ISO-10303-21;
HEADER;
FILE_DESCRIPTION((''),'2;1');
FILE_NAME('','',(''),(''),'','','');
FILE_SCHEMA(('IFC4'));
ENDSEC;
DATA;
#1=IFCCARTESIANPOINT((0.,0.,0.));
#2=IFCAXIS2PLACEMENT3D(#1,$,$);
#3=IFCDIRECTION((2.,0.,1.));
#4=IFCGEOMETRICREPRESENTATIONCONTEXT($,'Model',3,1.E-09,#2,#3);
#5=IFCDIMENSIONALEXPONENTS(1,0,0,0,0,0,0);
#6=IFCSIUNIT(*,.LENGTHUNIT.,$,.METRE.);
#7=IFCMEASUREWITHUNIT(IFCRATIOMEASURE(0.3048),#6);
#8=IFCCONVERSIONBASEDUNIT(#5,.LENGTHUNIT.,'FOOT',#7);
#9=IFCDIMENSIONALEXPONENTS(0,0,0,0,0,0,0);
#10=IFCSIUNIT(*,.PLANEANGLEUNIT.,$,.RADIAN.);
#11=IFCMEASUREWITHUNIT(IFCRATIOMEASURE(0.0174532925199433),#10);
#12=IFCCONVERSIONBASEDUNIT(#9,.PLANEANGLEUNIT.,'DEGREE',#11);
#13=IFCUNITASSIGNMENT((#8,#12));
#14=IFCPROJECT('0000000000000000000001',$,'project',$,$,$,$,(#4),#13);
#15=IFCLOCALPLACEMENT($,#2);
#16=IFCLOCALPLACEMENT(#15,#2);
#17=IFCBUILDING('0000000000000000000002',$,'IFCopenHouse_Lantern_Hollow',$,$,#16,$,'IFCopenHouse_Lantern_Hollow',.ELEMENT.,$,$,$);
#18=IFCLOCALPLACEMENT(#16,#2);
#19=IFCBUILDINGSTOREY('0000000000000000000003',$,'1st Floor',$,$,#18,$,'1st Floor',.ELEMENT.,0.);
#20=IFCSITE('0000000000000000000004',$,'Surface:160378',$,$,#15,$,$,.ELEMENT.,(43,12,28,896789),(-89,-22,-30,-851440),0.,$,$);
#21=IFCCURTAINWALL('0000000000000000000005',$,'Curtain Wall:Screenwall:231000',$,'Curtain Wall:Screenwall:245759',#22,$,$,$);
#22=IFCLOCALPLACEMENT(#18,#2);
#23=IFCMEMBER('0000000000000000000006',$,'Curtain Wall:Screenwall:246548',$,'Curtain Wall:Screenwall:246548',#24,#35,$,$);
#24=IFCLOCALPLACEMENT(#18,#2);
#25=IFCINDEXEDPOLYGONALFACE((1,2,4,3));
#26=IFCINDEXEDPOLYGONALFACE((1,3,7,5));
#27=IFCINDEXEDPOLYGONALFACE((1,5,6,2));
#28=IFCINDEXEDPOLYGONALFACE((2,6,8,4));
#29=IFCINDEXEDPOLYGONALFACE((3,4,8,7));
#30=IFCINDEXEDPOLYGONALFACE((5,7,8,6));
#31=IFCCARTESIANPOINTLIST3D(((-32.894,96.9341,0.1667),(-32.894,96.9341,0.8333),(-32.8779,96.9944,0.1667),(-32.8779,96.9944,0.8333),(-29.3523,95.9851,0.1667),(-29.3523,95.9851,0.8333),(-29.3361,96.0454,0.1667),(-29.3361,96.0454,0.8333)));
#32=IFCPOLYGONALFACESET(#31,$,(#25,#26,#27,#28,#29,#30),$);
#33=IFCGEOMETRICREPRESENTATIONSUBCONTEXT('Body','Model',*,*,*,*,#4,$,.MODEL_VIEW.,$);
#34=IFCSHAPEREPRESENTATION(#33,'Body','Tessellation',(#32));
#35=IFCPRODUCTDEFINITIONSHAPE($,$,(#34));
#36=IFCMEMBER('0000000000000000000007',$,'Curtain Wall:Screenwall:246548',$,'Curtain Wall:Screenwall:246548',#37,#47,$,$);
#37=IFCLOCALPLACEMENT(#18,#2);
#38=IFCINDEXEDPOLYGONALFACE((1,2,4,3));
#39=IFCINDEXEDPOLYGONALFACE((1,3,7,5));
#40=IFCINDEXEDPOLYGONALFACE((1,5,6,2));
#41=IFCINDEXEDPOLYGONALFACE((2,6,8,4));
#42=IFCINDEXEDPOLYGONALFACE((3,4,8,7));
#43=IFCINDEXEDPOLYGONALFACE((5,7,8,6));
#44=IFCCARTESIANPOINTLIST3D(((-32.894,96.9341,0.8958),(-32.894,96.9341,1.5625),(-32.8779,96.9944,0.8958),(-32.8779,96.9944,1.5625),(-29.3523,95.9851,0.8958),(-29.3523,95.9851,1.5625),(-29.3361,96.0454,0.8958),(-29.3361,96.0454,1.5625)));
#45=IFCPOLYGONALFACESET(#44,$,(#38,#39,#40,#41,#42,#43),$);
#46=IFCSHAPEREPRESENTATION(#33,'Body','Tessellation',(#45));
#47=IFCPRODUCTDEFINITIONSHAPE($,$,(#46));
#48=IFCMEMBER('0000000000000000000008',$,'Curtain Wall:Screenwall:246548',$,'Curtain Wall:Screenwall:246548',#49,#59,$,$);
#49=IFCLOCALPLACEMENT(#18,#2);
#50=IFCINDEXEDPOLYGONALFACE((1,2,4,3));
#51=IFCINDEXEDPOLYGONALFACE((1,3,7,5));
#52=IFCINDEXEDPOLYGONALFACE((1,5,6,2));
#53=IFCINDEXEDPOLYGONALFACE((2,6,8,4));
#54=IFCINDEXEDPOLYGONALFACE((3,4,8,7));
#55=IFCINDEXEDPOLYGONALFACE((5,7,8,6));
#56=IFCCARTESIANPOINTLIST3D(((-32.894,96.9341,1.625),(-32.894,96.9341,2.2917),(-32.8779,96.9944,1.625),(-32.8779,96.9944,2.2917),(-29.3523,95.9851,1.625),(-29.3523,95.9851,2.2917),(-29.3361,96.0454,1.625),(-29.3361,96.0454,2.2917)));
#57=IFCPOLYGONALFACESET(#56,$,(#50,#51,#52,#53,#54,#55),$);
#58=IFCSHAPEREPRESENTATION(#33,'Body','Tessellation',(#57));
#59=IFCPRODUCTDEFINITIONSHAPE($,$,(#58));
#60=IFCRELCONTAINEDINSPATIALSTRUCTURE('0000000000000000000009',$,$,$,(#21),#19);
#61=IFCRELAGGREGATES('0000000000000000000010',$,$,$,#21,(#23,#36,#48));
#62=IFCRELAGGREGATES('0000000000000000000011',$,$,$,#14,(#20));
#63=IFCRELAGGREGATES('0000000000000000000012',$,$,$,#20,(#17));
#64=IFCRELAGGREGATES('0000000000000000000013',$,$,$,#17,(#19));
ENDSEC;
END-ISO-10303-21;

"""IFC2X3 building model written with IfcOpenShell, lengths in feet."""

from ifc_helpers import new_model, entity, si_unit, converted_unit, direction, frame, frame_2d, origin, place, context, subcontext, project, spatial, rectangle, extrude, element, aggregate, save


model = new_model("IFC2X3")

# Units and contexts
model_context = context("Model", 3, precision=1e-09, world=origin(), true_north=direction((2.0, 0.0, 1.0)))
body_context = subcontext(model_context, "Body", "Model", "MODEL_VIEW")
ifc_project = project(units=[converted_unit("LENGTHUNIT", "FOOT", entity("IfcRatioMeasure", 0.3048), si_unit("LENGTHUNIT", "METRE"), dimensions=[1, 0, 0, 0, 0, 0, 0]), converted_unit("PLANEANGLEUNIT", "DEGREE", entity("IfcRatioMeasure", 0.0174532925199433), si_unit("PLANEANGLEUNIT", "RADIAN"), dimensions=[0, 0, 0, 0, 0, 0, 0])], contexts=[model_context])

# Site, building, storey
site_placement = place(None, origin())
site = spatial("IfcSite", under=ifc_project, at=site_placement, Name="Surface:160378", CompositionType="ELEMENT", RefLatitude=(43, 12, 28, 896789), RefLongitude=(-89, -22, -30, -851440), RefElevation=0.0)
building_placement = place(site_placement, origin())
building = spatial("IfcBuilding", under=site, at=building_placement, Name="IFCopenHouse_Lantern_Hollow", LongName="IFCopenHouse_Lantern_Hollow", CompositionType="ELEMENT")
storey_placement = place(building_placement, origin())
storey = spatial("IfcBuildingStorey", under=building, at=storey_placement, Name="1st Floor", LongName="1st Floor", CompositionType="ELEMENT", Elevation=0.0)

# Curtain wall, members
curtain_wall_placement = place(storey_placement, origin())
curtain_wall = element("IfcCurtainWall", 1, at=curtain_wall_placement, inside=storey, Name="Curtain Wall:Screenwall:231000", ObjectType="Curtain Wall:Screenwall:245759")
member_1_placement = place(curtain_wall_placement, frame((-32.894, 95.9851, 0.1667)))
member_1 = element("IfcMember", 2, at=member_1_placement, Name="Curtain Wall:Screenwall:246548", ObjectType="Curtain Wall:Screenwall:246548", context=body_context, shape_type="SweptSolid", body=[
    extrude(rectangle(XDim=3.6667, YDim=0.0625, at=frame_2d((0.0, 0.0), x_axis=(1.0, 0.0))), frame((1.779, 0.5047, 0.0), z_axis=(0.0, 0.0, 1.0), x_axis=(-0.965926, 0.258819, 0.0)), (0.0, 0.0, 1.0), 0.6667),
])
member_2_placement = place(curtain_wall_placement, frame((-32.894, 95.9851, 0.8958)))
member_2 = element("IfcMember", 3, at=member_2_placement, Name="Curtain Wall:Screenwall:246548", ObjectType="Curtain Wall:Screenwall:246548", context=body_context, shape_type="SweptSolid", body=[
    extrude(rectangle(XDim=3.6667, YDim=0.0625, at=frame_2d((0.0, 0.0), x_axis=(1.0, 0.0))), frame((1.779, 0.5047, 0.0), z_axis=(0.0, 0.0, 1.0), x_axis=(-0.965926, 0.258819, 0.0)), (0.0, 0.0, 1.0), 0.6667),
])
member_3_placement = place(curtain_wall_placement, frame((-32.894, 95.9851, 1.625)))
member_3 = element("IfcMember", 4, at=member_3_placement, Name="Curtain Wall:Screenwall:246548", ObjectType="Curtain Wall:Screenwall:246548", context=body_context, shape_type="SweptSolid", body=[
    extrude(rectangle(XDim=3.6667, YDim=0.0625, at=frame_2d((0.0, 0.0), x_axis=(1.0, 0.0))), frame((1.779, 0.5047, 0.0), z_axis=(0.0, 0.0, 1.0), x_axis=(-0.965926, 0.258819, 0.0)), (0.0, 0.0, 1.0), 0.6667),
])
aggregate(curtain_wall, [member_1, member_2, member_3])

save(model, "model.ifc")
